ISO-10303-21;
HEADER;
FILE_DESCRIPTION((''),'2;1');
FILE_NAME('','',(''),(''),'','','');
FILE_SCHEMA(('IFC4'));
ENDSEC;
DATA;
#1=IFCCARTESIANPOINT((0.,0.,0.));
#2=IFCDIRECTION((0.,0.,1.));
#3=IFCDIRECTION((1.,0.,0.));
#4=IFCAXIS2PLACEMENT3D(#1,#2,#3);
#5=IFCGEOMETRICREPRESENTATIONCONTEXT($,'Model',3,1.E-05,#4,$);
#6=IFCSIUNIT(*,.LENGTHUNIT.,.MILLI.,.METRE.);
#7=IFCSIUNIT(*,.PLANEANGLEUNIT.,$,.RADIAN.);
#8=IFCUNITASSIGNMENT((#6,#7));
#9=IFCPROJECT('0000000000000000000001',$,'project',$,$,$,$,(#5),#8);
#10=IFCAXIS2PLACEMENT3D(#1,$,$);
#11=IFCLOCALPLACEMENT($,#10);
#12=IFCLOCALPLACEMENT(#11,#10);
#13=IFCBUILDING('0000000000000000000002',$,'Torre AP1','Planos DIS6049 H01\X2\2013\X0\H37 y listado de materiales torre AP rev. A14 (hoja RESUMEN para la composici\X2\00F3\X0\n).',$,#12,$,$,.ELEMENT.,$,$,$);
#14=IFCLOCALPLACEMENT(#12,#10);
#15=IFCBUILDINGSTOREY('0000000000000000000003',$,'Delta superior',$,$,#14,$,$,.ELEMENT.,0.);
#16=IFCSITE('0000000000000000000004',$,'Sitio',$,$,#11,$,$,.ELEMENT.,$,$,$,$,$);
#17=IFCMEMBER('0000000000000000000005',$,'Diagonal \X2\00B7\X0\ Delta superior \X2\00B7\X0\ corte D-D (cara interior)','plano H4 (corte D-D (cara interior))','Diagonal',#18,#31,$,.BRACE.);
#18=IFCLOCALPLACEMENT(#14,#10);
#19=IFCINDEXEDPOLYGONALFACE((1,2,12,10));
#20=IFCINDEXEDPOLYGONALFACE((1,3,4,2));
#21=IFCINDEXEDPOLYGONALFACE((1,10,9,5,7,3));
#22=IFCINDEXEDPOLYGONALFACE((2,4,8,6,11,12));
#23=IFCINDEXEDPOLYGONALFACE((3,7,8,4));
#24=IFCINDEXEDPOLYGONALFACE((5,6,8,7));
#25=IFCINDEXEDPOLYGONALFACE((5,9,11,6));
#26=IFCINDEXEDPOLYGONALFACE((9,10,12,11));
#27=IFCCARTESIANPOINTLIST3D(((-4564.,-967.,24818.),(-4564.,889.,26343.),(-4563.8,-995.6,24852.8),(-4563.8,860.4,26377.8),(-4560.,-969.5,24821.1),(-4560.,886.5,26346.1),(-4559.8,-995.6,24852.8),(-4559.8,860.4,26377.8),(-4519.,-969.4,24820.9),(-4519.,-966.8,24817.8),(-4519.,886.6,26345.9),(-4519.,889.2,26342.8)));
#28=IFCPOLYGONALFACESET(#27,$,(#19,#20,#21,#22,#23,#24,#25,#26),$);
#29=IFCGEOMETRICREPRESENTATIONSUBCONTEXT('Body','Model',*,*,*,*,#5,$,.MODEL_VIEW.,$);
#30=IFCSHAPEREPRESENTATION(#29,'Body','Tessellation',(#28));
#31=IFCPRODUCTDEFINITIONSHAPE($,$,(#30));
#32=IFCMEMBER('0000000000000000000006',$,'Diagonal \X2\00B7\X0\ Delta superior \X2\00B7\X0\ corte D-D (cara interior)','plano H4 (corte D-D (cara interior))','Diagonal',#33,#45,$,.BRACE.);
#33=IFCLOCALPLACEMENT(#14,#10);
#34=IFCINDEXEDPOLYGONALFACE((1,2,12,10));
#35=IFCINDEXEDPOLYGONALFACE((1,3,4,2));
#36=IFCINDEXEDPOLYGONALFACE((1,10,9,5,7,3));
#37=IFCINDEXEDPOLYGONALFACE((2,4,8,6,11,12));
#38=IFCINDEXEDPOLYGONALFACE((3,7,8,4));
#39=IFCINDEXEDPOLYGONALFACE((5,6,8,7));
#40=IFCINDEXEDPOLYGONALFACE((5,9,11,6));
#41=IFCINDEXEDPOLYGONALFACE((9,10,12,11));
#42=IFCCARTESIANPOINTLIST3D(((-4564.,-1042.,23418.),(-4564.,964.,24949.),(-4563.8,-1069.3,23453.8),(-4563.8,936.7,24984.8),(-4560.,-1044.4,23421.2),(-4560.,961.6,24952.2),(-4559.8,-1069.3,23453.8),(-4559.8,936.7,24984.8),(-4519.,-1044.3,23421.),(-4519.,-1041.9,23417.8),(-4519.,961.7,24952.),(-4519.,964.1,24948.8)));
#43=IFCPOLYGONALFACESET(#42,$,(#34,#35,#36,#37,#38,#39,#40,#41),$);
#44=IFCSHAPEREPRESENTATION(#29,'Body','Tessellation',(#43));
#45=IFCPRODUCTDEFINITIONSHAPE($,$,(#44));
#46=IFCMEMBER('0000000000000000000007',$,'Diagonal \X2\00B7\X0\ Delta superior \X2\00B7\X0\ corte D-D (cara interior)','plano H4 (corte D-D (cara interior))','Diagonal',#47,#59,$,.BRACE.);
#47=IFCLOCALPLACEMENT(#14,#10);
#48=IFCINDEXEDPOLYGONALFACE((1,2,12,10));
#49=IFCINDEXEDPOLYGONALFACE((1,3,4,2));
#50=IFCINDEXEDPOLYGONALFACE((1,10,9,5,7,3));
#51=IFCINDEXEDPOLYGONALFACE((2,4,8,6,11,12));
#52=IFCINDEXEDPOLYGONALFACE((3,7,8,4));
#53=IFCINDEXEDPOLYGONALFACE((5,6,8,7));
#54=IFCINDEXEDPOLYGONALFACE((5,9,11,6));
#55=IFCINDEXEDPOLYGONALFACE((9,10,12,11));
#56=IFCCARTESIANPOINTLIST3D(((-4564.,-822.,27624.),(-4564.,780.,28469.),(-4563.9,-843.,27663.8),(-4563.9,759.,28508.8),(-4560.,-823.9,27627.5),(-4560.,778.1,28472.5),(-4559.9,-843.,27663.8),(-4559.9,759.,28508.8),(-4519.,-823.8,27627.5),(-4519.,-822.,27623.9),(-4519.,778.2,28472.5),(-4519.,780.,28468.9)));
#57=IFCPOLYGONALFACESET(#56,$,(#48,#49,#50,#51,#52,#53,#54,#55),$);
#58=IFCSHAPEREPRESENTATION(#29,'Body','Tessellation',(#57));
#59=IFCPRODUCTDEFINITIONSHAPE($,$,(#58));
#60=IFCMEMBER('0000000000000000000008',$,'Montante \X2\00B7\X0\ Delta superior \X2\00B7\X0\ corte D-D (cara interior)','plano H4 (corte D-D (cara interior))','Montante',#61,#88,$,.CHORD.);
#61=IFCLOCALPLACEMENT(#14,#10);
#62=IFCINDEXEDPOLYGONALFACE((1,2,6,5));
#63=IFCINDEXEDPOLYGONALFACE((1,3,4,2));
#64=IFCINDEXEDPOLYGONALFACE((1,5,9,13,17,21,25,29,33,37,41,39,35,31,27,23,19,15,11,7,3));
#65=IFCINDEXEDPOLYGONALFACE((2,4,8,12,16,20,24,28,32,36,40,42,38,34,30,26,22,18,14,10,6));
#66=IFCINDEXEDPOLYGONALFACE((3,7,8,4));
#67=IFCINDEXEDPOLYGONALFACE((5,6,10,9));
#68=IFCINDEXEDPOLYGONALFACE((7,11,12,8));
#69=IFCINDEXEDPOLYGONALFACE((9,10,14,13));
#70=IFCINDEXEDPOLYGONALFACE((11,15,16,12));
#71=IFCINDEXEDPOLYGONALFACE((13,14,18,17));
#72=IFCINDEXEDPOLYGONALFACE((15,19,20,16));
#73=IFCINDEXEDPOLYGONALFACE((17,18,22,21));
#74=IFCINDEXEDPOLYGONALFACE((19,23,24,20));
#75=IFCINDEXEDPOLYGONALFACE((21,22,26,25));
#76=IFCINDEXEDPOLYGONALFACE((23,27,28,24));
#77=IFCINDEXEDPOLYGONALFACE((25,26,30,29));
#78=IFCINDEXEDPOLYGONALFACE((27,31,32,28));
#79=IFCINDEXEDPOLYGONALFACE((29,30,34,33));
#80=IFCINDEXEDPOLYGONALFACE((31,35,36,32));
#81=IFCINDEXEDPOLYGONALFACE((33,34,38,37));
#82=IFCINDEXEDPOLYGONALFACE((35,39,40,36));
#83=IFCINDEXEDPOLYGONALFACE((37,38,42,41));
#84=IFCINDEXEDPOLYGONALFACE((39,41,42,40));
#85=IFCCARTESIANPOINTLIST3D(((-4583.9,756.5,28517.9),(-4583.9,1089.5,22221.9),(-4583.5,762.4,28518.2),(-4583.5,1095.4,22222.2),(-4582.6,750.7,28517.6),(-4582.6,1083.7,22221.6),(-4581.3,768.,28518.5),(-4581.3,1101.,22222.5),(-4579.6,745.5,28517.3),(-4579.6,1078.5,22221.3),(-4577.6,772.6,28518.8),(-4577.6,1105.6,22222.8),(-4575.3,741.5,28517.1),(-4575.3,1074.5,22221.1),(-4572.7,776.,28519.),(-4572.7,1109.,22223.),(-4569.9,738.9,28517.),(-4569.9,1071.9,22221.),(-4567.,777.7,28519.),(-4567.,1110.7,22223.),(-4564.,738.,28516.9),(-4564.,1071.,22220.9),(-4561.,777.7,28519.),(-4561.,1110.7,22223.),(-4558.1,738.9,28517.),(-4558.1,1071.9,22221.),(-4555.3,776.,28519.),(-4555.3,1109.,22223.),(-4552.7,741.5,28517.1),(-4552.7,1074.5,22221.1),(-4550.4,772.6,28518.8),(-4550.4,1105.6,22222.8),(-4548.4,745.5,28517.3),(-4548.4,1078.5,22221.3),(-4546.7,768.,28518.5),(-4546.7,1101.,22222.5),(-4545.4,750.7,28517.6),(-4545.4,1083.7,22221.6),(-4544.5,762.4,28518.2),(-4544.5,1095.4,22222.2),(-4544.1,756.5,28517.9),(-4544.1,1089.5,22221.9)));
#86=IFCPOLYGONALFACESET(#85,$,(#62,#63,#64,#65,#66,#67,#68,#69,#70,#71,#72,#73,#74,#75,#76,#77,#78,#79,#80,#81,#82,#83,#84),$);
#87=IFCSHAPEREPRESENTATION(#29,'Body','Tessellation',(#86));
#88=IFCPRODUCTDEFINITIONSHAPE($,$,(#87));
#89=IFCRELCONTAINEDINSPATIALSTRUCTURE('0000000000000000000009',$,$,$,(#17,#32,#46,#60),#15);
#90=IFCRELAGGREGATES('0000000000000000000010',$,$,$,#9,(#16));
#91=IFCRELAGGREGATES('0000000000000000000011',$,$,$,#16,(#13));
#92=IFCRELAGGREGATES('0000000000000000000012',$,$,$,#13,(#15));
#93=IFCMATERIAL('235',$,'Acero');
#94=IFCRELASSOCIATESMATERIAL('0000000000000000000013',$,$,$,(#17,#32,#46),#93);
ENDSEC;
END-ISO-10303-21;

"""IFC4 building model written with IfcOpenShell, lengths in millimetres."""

from ifc_helpers import new_model, si_unit, frame, frame_2d, origin, origin_with_axes, place, context, subcontext, project, spatial, circle, l_section, extrude, material, element, save


model = new_model("IFC4")

# Units and contexts
model_context = context("Model", 3, precision=1e-05, world=origin_with_axes())
body_context = subcontext(model_context, "Body", "Model", "MODEL_VIEW")
ifc_project = project(units=[si_unit("LENGTHUNIT", "METRE", prefix="MILLI"), si_unit("PLANEANGLEUNIT", "RADIAN")], contexts=[model_context])

# Site, building, storey
site_placement = place(None, origin())
site = spatial("IfcSite", under=ifc_project, at=site_placement, Name="Sitio", CompositionType="ELEMENT")
building_placement = place(site_placement, origin())
building = spatial("IfcBuilding", under=site, at=building_placement, Name="Torre AP1", Description="Planos DIS6049 H01–H37 y listado de materiales torre AP rev. A14 (hoja RESUMEN para la composición).", CompositionType="ELEMENT")
storey_placement = place(building_placement, origin())
storey = spatial("IfcBuildingStorey", under=building, at=storey_placement, Name="Delta superior", CompositionType="ELEMENT", Elevation=0.0)

# Members
ifc_material_1 = material(Name="235", Category="Acero")
member_1_placement = place(storey_placement, frame((-4564.0, 889.0, 26343.0), z_axis=(0.0, -0.772639, -0.634846), x_axis=(0.999985, 0.003444, -0.004191)))
element("IfcMember", 1, at=member_1_placement, inside=storey, material=ifc_material_1, Name="Diagonal · Delta superior · corte D-D (cara interior)", Description="plano H4 (corte D-D (cara interior))", ObjectType="Diagonal", PredefinedType="BRACE", context=body_context, shape_type="SweptSolid", body=[
    extrude(l_section(Depth=45.0, Width=45.0, Thickness=4.0, at=frame_2d((22.5, 22.5))), None, (0.0, 0.0, 1.0), 2402.2),
])
member_2_placement = place(storey_placement, frame((-4564.0, 964.0, 24949.0), z_axis=(0.0, -0.794931, -0.6067), x_axis=(0.999987, 0.003145, -0.004121)))
element("IfcMember", 2, at=member_2_placement, inside=storey, material=ifc_material_1, Name="Diagonal · Delta superior · corte D-D (cara interior)", Description="plano H4 (corte D-D (cara interior))", ObjectType="Diagonal", PredefinedType="BRACE", context=body_context, shape_type="SweptSolid", body=[
    extrude(l_section(Depth=45.0, Width=45.0, Thickness=4.0, at=frame_2d((22.5, 22.5))), None, (0.0, 0.0, 1.0), 2523.5),
])
member_3_placement = place(storey_placement, frame((-4564.0, 780.0, 28469.0), z_axis=(0.0, -0.884499, -0.466543), x_axis=(0.999998, 0.001002, -0.001899)))
element("IfcMember", 3, at=member_3_placement, inside=storey, material=ifc_material_1, Name="Diagonal · Delta superior · corte D-D (cara interior)", Description="plano H4 (corte D-D (cara interior))", ObjectType="Diagonal", PredefinedType="BRACE", context=body_context, shape_type="SweptSolid", body=[
    extrude(l_section(Depth=45.0, Width=45.0, Thickness=4.0, at=frame_2d((22.5, 22.5))), None, (0.0, 0.0, 1.0), 1811.2),
])
member_4_placement = place(storey_placement, frame((-4564.0, 1091.0, 22222.0), z_axis=(0.0, -0.052817, 0.998604), x_axis=(0.0, -0.998604, -0.052817)))
element("IfcMember", 4, at=member_4_placement, inside=storey, Name="Montante · Delta superior · corte D-D (cara interior)", Description="plano H4 (corte D-D (cara interior))", ObjectType="Montante", PredefinedType="CHORD", context=body_context, shape_type="SweptSolid", body=[
    extrude(circle(Radius=20.0), None, (0.0, 0.0, 1.0), 6304.8),
])

save(model, "model.ifc")
